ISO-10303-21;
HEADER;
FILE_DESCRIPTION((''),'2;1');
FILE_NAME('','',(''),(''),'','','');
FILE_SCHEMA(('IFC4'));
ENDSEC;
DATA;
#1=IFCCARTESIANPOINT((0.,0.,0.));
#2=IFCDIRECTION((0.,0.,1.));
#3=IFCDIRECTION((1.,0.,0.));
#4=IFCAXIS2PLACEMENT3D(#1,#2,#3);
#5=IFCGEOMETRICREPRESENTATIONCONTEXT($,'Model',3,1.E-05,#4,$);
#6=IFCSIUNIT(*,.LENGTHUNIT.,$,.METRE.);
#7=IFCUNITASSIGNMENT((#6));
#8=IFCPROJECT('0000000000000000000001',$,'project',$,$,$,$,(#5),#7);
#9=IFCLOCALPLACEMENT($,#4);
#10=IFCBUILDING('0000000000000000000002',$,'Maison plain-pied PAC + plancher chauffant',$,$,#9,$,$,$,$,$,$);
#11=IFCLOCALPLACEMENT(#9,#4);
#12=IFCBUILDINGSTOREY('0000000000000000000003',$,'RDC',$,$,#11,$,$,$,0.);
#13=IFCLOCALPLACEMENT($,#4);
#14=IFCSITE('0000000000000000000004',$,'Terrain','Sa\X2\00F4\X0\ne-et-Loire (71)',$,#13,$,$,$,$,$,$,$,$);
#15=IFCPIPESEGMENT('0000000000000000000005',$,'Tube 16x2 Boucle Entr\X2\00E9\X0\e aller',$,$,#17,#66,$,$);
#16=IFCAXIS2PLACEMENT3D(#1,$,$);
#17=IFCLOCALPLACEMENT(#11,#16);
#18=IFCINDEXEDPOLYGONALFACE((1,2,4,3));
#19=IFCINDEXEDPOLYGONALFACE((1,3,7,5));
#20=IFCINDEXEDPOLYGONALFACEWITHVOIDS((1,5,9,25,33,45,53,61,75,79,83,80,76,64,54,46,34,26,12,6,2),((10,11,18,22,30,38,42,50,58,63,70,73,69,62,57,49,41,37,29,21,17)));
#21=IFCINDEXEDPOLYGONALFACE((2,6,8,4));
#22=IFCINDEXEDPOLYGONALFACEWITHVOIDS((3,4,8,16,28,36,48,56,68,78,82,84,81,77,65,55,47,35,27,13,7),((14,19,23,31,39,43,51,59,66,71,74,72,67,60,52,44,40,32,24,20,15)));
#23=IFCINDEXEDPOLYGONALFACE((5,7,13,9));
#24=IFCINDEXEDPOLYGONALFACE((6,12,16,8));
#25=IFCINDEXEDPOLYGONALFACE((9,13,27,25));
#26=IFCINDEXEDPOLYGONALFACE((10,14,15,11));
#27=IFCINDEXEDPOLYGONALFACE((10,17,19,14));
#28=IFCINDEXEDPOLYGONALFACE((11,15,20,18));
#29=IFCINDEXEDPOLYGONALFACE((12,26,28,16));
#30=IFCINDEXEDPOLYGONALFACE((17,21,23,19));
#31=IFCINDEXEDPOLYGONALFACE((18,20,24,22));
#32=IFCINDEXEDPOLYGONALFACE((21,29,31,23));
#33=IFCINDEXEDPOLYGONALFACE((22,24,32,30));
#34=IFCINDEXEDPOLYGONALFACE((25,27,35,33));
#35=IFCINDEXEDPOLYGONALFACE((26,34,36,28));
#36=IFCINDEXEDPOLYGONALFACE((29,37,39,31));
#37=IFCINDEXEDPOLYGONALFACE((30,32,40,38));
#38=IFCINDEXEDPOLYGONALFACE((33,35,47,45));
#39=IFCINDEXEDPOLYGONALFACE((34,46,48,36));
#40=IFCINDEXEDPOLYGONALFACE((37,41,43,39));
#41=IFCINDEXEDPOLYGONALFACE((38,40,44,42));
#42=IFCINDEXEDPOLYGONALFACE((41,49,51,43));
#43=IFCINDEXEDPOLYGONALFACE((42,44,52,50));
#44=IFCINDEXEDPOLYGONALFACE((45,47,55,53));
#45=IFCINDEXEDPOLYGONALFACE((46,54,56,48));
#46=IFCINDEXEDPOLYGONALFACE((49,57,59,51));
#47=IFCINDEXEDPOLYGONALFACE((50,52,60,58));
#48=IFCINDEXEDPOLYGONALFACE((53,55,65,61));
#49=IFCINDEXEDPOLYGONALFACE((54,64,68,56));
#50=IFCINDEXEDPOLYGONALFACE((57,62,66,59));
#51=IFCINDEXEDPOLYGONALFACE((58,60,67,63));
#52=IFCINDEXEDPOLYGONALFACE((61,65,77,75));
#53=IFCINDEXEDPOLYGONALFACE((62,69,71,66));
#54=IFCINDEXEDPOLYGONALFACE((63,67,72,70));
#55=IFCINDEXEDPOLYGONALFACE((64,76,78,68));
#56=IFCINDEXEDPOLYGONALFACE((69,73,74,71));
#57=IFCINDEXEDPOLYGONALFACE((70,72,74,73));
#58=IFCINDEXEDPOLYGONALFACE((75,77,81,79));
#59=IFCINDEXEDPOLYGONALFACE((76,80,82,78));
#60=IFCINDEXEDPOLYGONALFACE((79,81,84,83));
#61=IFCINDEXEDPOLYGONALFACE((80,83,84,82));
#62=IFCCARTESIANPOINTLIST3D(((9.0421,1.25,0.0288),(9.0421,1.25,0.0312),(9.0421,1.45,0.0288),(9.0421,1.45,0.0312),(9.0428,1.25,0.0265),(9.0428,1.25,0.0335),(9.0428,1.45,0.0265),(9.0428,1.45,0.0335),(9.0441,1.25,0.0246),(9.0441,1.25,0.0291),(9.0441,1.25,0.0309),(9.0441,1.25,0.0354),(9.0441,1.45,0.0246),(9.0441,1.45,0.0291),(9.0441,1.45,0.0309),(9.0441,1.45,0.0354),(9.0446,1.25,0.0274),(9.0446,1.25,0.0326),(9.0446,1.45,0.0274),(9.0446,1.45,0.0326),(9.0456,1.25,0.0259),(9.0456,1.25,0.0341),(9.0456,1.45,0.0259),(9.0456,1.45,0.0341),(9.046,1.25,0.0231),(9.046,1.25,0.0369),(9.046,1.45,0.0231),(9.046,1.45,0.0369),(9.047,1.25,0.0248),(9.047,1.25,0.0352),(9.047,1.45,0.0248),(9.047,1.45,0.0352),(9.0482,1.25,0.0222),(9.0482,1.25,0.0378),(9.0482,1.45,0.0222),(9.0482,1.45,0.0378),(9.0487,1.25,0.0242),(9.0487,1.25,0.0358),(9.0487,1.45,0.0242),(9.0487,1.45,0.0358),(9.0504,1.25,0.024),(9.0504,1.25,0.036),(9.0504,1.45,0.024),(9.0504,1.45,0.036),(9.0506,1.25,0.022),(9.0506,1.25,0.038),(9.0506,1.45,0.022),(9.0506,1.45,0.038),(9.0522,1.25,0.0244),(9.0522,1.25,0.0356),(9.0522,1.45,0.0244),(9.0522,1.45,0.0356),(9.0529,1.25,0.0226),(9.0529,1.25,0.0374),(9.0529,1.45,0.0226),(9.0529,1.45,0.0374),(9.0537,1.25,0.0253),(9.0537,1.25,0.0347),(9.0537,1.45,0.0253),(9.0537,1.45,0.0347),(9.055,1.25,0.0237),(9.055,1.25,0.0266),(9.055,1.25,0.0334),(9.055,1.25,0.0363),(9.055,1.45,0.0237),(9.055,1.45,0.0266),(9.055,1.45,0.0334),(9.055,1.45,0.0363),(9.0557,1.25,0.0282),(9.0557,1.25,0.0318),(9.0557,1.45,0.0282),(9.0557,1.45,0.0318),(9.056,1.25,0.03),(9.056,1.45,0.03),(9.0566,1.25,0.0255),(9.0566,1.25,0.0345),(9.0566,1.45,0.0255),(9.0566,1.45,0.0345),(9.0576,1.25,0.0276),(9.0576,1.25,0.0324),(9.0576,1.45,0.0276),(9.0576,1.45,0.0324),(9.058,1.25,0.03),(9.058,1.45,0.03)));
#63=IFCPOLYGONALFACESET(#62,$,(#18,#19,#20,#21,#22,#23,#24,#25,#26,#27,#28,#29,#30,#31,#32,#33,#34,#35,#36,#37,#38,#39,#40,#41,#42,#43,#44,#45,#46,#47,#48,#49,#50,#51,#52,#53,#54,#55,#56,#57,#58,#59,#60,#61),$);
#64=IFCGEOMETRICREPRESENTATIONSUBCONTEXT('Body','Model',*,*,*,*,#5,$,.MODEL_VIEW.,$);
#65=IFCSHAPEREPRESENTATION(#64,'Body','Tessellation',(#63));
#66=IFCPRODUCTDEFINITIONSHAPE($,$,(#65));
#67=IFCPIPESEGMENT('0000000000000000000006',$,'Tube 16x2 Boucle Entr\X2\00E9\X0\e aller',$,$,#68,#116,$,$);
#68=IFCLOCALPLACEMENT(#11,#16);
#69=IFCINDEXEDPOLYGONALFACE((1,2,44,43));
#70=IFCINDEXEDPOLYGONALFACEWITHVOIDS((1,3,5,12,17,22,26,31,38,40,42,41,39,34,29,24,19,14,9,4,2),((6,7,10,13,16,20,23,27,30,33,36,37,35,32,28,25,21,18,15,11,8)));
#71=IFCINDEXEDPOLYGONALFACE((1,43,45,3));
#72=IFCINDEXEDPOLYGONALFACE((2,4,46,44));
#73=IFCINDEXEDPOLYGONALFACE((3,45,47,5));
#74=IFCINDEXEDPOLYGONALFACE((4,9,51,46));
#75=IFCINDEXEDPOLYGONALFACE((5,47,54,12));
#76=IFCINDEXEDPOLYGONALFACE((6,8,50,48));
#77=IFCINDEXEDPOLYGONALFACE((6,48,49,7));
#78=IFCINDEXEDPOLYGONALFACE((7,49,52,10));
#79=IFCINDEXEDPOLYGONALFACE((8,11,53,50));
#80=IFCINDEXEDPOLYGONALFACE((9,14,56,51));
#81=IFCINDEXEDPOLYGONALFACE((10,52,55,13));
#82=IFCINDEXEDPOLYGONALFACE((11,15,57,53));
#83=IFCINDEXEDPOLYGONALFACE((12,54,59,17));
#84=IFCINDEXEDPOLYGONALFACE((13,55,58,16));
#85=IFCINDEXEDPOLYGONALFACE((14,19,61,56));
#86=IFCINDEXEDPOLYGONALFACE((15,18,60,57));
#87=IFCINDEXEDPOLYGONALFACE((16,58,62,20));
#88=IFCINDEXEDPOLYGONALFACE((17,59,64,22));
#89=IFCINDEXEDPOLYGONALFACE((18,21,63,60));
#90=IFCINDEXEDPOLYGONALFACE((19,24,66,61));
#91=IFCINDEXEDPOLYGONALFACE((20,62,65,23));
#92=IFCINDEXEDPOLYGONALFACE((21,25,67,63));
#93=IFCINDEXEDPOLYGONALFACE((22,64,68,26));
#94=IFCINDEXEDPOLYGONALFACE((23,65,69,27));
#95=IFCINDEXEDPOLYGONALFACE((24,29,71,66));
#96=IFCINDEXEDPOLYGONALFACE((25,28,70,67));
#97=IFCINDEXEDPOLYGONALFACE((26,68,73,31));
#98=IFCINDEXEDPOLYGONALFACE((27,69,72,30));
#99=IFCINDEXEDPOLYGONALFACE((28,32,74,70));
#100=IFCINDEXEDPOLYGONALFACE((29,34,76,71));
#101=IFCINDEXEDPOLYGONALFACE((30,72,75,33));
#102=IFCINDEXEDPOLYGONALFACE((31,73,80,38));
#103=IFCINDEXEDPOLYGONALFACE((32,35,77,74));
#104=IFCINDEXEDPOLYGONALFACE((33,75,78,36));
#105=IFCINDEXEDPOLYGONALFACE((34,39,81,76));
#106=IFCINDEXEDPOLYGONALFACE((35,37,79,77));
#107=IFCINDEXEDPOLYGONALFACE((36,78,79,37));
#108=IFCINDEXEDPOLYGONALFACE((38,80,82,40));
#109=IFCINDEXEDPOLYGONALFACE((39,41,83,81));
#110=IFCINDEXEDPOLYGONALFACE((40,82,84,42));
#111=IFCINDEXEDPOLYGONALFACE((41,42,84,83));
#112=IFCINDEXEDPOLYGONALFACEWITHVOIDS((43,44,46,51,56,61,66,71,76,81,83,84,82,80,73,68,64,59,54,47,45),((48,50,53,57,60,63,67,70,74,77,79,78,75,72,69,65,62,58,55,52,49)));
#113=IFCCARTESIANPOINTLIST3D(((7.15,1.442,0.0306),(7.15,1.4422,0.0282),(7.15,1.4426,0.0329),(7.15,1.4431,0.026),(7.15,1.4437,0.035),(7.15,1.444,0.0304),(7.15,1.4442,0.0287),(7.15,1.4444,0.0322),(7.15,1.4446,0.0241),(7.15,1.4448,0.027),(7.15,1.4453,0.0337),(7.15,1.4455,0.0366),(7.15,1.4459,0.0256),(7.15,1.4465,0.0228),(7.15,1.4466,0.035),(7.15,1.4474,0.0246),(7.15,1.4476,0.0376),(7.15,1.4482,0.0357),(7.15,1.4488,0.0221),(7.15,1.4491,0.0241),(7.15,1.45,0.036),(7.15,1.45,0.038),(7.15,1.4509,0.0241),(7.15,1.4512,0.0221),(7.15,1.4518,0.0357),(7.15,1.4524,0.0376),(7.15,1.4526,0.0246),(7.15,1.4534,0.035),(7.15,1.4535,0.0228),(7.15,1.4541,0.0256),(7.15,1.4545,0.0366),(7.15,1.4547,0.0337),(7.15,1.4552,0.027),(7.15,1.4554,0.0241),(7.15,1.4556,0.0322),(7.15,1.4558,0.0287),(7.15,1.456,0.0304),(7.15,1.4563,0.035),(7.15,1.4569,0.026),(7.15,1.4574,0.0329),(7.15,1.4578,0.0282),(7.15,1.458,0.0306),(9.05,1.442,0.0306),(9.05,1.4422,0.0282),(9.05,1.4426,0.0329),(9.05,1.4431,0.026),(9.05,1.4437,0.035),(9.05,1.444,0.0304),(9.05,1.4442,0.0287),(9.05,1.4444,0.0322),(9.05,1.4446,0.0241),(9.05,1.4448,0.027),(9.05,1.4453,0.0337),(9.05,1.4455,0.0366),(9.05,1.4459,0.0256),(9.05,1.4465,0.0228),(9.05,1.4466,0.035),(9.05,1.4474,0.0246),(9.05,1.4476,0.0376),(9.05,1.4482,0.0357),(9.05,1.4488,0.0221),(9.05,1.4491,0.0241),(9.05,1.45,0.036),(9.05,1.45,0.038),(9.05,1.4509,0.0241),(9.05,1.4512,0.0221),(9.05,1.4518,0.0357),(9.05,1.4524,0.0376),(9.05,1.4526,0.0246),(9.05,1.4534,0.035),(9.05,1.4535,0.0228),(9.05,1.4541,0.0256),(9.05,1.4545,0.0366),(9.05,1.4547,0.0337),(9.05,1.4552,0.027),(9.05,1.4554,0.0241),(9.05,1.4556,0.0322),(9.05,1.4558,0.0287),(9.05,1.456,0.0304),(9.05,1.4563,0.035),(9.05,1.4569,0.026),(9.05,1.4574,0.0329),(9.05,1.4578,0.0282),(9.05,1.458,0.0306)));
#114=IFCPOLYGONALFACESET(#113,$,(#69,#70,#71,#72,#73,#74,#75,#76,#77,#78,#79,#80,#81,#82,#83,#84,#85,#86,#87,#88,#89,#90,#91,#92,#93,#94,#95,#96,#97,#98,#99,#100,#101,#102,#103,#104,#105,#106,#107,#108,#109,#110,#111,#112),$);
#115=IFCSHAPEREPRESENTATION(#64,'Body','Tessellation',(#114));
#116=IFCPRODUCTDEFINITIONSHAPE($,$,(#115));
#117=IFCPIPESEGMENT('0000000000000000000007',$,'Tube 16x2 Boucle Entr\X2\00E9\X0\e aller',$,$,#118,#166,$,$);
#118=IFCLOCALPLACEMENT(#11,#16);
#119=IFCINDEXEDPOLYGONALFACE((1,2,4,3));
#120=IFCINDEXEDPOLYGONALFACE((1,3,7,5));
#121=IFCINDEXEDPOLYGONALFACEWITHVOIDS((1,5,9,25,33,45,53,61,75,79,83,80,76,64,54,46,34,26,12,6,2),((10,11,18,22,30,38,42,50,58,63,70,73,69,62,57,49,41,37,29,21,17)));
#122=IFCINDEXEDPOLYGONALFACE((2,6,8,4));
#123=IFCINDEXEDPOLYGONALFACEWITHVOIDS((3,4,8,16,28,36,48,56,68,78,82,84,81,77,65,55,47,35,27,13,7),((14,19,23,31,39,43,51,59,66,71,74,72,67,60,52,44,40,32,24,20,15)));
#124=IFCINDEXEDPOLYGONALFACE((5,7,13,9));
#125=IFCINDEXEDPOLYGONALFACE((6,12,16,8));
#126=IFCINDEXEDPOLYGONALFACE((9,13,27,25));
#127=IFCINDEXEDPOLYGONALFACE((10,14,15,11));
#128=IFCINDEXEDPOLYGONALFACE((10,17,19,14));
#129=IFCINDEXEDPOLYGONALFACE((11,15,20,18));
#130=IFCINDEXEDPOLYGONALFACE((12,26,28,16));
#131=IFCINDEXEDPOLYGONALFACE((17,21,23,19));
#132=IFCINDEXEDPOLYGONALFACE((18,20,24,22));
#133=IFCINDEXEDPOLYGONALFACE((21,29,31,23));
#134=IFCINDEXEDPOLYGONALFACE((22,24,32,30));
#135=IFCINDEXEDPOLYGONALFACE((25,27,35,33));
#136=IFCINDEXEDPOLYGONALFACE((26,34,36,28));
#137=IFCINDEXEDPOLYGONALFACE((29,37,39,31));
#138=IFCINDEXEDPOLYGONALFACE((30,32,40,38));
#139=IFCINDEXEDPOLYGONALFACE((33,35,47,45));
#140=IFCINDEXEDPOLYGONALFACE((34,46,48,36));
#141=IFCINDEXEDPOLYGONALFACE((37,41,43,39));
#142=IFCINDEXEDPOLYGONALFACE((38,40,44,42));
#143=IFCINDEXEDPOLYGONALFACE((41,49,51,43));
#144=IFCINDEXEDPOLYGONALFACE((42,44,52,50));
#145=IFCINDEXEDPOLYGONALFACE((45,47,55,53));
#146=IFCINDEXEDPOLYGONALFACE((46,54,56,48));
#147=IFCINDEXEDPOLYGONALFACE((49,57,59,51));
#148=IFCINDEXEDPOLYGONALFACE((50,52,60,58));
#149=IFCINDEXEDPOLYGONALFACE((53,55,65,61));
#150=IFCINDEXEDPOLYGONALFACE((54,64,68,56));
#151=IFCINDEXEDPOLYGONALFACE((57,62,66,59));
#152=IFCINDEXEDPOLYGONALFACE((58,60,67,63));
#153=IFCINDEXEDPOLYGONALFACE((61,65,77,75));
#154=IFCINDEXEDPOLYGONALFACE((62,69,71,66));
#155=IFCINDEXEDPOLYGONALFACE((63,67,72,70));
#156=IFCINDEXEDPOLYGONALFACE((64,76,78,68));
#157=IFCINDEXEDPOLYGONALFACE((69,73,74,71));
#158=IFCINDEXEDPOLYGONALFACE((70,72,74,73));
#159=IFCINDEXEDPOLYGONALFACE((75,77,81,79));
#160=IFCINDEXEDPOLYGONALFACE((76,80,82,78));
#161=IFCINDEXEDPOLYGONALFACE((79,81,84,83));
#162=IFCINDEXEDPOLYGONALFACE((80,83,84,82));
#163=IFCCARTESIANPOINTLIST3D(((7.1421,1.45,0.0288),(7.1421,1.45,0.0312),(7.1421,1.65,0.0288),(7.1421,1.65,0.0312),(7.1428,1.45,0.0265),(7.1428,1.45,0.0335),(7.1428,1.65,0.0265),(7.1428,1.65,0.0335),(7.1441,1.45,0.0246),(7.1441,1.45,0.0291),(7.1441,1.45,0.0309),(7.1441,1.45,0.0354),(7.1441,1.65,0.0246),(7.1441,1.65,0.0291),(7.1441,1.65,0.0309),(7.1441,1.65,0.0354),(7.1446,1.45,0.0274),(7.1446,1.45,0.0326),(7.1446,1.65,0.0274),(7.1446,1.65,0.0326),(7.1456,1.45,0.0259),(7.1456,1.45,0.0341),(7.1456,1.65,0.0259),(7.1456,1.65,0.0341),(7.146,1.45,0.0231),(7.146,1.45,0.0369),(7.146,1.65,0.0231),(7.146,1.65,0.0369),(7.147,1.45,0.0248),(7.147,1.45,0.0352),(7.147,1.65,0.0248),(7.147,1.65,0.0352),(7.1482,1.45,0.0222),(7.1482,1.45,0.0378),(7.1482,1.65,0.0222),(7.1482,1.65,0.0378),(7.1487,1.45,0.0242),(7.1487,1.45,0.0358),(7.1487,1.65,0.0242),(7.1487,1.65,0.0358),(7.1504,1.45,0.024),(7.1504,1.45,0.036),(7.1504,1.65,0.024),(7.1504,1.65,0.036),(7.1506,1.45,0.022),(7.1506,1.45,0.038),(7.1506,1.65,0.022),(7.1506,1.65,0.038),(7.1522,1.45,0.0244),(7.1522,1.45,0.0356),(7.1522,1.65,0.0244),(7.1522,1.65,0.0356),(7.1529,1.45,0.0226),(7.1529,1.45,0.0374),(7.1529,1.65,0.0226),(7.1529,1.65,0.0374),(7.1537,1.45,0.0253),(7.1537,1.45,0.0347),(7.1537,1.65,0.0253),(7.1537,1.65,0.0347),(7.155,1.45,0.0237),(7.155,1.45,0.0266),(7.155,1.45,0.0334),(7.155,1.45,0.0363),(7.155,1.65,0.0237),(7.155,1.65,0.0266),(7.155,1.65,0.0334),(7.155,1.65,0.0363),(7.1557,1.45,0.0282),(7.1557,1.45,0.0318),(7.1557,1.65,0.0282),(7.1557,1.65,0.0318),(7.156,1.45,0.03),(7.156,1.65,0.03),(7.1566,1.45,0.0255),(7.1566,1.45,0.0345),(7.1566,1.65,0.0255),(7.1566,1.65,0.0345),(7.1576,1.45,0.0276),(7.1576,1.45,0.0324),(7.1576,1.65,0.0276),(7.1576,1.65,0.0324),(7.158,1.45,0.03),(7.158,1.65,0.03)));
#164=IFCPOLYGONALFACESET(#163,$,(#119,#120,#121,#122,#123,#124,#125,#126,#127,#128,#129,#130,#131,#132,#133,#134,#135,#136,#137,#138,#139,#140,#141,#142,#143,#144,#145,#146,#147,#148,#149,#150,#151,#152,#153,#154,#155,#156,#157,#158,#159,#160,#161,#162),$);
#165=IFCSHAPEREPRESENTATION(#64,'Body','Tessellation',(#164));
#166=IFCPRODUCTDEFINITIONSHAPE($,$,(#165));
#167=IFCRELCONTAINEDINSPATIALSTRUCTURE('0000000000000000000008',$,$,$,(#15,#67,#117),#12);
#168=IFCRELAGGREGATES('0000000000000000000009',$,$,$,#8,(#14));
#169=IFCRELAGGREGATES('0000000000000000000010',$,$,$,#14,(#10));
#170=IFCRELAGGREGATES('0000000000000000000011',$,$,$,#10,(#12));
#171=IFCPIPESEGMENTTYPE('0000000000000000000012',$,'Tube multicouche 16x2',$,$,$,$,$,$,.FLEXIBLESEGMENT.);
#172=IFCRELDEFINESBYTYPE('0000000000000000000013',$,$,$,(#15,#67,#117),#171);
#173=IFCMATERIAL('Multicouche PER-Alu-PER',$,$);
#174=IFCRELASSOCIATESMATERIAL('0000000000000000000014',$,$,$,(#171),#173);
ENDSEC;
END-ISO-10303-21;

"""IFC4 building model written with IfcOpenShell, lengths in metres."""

from ifc_helpers import new_model, si_unit, frame, origin_with_axes, place, context, subcontext, project, spatial, hollow_circle, extrude, material, type_object, element, save


model = new_model("IFC4")

# Units and contexts
model_context = context("Model", 3, precision=1e-05, world=origin_with_axes())
body_context = subcontext(model_context, "Body", "Model", "MODEL_VIEW")
ifc_project = project(units=[si_unit("LENGTHUNIT", "METRE")], contexts=[model_context])

# Site, building, storey
site_placement = place(None, origin_with_axes())
site = spatial("IfcSite", under=ifc_project, at=site_placement, Name="Terrain", Description="Saône-et-Loire (71)")
building_placement = place(None, origin_with_axes())
building = spatial("IfcBuilding", under=site, at=building_placement, Name="Maison plain-pied PAC + plancher chauffant")
storey_placement = place(building_placement, origin_with_axes())
storey = spatial("IfcBuildingStorey", under=building, at=storey_placement, Name="RDC", Elevation=0.0)

# Pipe segments
ifc_material_1 = material(Name="Multicouche PER-Alu-PER")
pipe_segment_type = type_object("IfcPipeSegmentType", Name="Tube multicouche 16x2", PredefinedType="FLEXIBLESEGMENT", material=ifc_material_1)
pipe_segment_1_placement = place(storey_placement, frame((9.05, 1.25, 0.03), z_axis=(0.0, 1.0, 0.0), x_axis=(1.0, 0.0, 0.0)))
element("IfcPipeSegment", 1, at=pipe_segment_1_placement, inside=storey, type_object=pipe_segment_type, Name="Tube 16x2 Boucle Entrée aller", context=body_context, shape_type="SweptSolid", body=[
    extrude(hollow_circle(Radius=0.008, WallThickness=0.002), origin_with_axes(), (0.0, 0.0, 1.0), 0.2),
])
pipe_segment_2_placement = place(storey_placement, frame((9.05, 1.45, 0.03), z_axis=(-1.0, 0.0, 0.0), x_axis=(0.0, 0.0, 1.0)))
element("IfcPipeSegment", 2, at=pipe_segment_2_placement, inside=storey, type_object=pipe_segment_type, Name="Tube 16x2 Boucle Entrée aller", context=body_context, shape_type="SweptSolid", body=[
    extrude(hollow_circle(Radius=0.008, WallThickness=0.002), origin_with_axes(), (0.0, 0.0, 1.0), 1.9),
])
pipe_segment_3_placement = place(storey_placement, frame((7.15, 1.45, 0.03), z_axis=(0.0, 1.0, 0.0), x_axis=(1.0, 0.0, 0.0)))
element("IfcPipeSegment", 3, at=pipe_segment_3_placement, inside=storey, type_object=pipe_segment_type, Name="Tube 16x2 Boucle Entrée aller", context=body_context, shape_type="SweptSolid", body=[
    extrude(hollow_circle(Radius=0.008, WallThickness=0.002), origin_with_axes(), (0.0, 0.0, 1.0), 0.2),
])

save(model, "model.ifc")
